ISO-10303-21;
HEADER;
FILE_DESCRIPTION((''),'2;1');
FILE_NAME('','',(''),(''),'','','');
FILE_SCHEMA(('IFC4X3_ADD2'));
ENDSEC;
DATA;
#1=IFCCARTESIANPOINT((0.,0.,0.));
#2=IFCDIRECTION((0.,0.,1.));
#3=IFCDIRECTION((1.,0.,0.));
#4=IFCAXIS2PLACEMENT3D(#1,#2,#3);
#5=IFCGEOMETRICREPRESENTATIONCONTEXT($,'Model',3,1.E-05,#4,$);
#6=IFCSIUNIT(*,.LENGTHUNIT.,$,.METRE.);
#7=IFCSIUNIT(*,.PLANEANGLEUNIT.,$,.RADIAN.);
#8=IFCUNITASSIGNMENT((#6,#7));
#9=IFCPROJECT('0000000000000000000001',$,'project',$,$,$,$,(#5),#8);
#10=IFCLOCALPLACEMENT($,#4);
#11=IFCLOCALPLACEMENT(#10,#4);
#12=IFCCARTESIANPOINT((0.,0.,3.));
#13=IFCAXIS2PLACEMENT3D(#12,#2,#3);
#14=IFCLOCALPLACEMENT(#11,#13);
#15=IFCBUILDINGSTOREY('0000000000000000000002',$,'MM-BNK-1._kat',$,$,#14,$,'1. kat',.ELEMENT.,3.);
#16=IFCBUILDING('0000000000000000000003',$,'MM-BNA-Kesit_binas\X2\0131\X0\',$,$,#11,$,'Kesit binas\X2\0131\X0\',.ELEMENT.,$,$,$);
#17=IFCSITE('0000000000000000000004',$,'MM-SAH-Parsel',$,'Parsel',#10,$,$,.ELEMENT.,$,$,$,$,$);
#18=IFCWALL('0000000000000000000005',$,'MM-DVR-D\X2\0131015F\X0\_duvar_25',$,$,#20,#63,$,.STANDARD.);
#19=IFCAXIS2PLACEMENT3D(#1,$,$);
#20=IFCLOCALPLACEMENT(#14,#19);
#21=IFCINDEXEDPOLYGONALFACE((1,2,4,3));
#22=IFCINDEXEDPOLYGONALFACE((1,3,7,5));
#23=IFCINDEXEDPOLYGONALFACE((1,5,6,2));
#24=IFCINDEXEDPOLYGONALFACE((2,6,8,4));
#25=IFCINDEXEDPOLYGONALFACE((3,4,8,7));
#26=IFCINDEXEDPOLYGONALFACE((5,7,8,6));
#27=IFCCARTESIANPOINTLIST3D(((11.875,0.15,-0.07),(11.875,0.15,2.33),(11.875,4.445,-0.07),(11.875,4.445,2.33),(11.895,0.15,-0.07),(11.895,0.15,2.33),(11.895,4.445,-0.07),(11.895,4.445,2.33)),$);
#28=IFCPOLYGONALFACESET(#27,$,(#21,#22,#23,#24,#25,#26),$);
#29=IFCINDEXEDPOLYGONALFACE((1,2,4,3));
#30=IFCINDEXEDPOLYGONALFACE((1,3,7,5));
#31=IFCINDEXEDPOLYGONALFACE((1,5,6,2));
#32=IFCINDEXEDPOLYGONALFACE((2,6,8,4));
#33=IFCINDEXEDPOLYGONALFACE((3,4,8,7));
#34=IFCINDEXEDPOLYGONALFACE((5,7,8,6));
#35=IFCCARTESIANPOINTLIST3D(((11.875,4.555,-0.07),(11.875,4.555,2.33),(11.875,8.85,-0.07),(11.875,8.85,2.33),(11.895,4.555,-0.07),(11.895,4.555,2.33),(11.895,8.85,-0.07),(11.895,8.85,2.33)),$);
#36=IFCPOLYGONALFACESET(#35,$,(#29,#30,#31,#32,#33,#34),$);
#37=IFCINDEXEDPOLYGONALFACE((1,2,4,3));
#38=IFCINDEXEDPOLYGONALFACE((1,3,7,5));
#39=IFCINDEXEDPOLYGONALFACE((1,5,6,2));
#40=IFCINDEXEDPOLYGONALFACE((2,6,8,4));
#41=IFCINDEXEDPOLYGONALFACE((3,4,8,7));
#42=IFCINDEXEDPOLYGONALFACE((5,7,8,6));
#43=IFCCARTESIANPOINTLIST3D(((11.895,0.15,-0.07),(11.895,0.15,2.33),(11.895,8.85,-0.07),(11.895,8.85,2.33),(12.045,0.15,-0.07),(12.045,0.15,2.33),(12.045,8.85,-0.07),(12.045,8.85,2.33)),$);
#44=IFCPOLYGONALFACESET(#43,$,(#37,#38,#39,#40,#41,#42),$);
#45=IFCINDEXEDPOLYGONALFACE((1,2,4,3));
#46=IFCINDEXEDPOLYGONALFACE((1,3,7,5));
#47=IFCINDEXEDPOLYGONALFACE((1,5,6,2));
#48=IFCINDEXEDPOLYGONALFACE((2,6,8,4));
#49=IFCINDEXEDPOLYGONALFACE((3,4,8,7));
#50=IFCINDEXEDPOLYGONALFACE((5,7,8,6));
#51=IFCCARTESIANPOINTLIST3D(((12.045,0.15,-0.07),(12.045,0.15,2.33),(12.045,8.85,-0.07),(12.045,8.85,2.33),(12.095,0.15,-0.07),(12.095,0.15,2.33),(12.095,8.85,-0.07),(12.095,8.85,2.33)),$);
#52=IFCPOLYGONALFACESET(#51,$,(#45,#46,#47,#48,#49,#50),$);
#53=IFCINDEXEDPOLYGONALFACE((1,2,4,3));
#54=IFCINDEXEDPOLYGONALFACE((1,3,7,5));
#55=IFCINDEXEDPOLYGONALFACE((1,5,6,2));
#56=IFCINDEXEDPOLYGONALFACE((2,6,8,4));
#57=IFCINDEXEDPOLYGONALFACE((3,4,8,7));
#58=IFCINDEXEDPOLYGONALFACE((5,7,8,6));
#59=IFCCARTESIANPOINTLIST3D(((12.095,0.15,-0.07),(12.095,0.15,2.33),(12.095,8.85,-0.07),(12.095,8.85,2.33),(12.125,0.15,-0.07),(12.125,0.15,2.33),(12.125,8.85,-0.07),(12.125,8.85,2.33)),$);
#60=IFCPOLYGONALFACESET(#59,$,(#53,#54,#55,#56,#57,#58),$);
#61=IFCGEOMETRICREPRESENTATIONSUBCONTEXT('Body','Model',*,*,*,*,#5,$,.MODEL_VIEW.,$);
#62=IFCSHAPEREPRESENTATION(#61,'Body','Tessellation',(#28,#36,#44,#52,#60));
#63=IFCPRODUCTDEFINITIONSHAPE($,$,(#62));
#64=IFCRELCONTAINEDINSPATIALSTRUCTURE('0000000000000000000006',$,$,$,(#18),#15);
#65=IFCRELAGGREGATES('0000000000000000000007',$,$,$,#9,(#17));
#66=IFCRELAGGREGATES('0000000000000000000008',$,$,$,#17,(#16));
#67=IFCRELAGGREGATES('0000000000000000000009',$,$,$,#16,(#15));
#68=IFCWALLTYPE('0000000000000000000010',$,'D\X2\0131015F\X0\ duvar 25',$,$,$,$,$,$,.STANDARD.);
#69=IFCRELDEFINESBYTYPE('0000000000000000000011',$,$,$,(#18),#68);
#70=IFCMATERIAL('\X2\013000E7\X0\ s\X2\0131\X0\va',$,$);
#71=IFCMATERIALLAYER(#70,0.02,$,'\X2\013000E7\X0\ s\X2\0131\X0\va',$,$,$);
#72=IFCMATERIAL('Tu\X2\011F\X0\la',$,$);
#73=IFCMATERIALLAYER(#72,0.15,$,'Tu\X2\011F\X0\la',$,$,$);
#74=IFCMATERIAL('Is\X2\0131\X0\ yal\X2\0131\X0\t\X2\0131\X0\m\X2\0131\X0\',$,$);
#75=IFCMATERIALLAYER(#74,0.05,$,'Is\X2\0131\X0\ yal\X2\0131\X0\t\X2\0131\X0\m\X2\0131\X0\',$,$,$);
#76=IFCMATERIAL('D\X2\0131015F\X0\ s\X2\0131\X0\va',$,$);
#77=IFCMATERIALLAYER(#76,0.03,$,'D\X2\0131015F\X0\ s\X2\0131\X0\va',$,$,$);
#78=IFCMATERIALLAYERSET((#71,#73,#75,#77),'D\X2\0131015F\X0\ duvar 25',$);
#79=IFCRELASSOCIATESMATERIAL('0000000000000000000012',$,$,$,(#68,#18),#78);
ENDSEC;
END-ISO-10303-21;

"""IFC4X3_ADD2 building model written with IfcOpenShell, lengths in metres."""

from ifc_helpers import new_model, si_unit, frame, origin_with_axes, place, context, subcontext, project, spatial, polyline, outline, extrude, material, layer, layer_set, type_object, element, save


model = new_model("IFC4X3_ADD2")

# Units and contexts
model_context = context("Model", 3, precision=1e-05, world=origin_with_axes())
body_context = subcontext(model_context, "Body", "Model", "MODEL_VIEW")
ifc_project = project(units=[si_unit("LENGTHUNIT", "METRE"), si_unit("PLANEANGLEUNIT", "RADIAN")], contexts=[model_context])

# Site, building, storey
site_placement = place(None, origin_with_axes())
site = spatial("IfcSite", under=ifc_project, at=site_placement, Name="MM-SAH-Parsel", ObjectType="Parsel", CompositionType="ELEMENT")
building_placement = place(site_placement, origin_with_axes())
building = spatial("IfcBuilding", under=site, at=building_placement, Name="MM-BNA-Kesit_binası", LongName="Kesit binası", CompositionType="ELEMENT")
storey_placement = place(building_placement, frame((0.0, 0.0, 3.0), z_axis=(0.0, 0.0, 1.0), x_axis=(1.0, 0.0, 0.0)))
storey = spatial("IfcBuildingStorey", under=building, at=storey_placement, Name="MM-BNK-1._kat", LongName="1. kat", CompositionType="ELEMENT", Elevation=3.0)

# Shared definitions
ifc_material_1 = material(Name="İç sıva")
ifc_layer_1 = layer(ifc_material_1, 0.02, Name="İç sıva")
ifc_material_2 = material(Name="Tuğla")
ifc_layer_2 = layer(ifc_material_2, 0.15, Name="Tuğla")
ifc_material_3 = material(Name="Isı yalıtımı")
ifc_layer_3 = layer(ifc_material_3, 0.05, Name="Isı yalıtımı")
ifc_material_4 = material(Name="Dış sıva")
ifc_layer_4 = layer(ifc_material_4, 0.03, Name="Dış sıva")
ifc_layer_set_1 = layer_set([ifc_layer_1, ifc_layer_2, ifc_layer_3, ifc_layer_4], Name="Dış duvar 25")
wall_type_1 = type_object("IfcWallType", Name="Dış duvar 25", PredefinedType="STANDARD", material=ifc_layer_set_1)

# Wall
wall_1_placement = place(storey_placement, origin_with_axes())
element("IfcWall", 1, at=wall_1_placement, inside=storey, type_object=wall_type_1, material=ifc_layer_set_1, Name="MM-DVR-Dış_duvar_25", PredefinedType="STANDARD", context=body_context, shape_type="SweptSolid", body=[
    extrude(outline(polyline([(11.895, 0.15), (11.895, 4.445), (11.875, 4.445), (11.875, 0.15), (11.895, 0.15)])), frame((0.0, 0.0, -0.07)), (0.0, 0.0, 1.0), 2.4),
    extrude(outline(polyline([(11.895, 4.555), (11.895, 8.85), (11.875, 8.85), (11.875, 4.555), (11.895, 4.555)])), frame((0.0, 0.0, -0.07)), (0.0, 0.0, 1.0), 2.4),
    extrude(outline(polyline([(12.045, 0.15), (12.045, 8.85), (11.895, 8.85), (11.895, 0.15), (12.045, 0.15)])), frame((0.0, 0.0, -0.07)), (0.0, 0.0, 1.0), 2.4),
    extrude(outline(polyline([(12.095, 0.15), (12.095, 8.85), (12.045, 8.85), (12.045, 0.15), (12.095, 0.15)])), frame((0.0, 0.0, -0.07)), (0.0, 0.0, 1.0), 2.4),
    extrude(outline(polyline([(12.125, 0.15), (12.125, 8.85), (12.095, 8.85), (12.095, 0.15), (12.125, 0.15)])), frame((0.0, 0.0, -0.07)), (0.0, 0.0, 1.0), 2.4),
])

save(model, "model.ifc")
